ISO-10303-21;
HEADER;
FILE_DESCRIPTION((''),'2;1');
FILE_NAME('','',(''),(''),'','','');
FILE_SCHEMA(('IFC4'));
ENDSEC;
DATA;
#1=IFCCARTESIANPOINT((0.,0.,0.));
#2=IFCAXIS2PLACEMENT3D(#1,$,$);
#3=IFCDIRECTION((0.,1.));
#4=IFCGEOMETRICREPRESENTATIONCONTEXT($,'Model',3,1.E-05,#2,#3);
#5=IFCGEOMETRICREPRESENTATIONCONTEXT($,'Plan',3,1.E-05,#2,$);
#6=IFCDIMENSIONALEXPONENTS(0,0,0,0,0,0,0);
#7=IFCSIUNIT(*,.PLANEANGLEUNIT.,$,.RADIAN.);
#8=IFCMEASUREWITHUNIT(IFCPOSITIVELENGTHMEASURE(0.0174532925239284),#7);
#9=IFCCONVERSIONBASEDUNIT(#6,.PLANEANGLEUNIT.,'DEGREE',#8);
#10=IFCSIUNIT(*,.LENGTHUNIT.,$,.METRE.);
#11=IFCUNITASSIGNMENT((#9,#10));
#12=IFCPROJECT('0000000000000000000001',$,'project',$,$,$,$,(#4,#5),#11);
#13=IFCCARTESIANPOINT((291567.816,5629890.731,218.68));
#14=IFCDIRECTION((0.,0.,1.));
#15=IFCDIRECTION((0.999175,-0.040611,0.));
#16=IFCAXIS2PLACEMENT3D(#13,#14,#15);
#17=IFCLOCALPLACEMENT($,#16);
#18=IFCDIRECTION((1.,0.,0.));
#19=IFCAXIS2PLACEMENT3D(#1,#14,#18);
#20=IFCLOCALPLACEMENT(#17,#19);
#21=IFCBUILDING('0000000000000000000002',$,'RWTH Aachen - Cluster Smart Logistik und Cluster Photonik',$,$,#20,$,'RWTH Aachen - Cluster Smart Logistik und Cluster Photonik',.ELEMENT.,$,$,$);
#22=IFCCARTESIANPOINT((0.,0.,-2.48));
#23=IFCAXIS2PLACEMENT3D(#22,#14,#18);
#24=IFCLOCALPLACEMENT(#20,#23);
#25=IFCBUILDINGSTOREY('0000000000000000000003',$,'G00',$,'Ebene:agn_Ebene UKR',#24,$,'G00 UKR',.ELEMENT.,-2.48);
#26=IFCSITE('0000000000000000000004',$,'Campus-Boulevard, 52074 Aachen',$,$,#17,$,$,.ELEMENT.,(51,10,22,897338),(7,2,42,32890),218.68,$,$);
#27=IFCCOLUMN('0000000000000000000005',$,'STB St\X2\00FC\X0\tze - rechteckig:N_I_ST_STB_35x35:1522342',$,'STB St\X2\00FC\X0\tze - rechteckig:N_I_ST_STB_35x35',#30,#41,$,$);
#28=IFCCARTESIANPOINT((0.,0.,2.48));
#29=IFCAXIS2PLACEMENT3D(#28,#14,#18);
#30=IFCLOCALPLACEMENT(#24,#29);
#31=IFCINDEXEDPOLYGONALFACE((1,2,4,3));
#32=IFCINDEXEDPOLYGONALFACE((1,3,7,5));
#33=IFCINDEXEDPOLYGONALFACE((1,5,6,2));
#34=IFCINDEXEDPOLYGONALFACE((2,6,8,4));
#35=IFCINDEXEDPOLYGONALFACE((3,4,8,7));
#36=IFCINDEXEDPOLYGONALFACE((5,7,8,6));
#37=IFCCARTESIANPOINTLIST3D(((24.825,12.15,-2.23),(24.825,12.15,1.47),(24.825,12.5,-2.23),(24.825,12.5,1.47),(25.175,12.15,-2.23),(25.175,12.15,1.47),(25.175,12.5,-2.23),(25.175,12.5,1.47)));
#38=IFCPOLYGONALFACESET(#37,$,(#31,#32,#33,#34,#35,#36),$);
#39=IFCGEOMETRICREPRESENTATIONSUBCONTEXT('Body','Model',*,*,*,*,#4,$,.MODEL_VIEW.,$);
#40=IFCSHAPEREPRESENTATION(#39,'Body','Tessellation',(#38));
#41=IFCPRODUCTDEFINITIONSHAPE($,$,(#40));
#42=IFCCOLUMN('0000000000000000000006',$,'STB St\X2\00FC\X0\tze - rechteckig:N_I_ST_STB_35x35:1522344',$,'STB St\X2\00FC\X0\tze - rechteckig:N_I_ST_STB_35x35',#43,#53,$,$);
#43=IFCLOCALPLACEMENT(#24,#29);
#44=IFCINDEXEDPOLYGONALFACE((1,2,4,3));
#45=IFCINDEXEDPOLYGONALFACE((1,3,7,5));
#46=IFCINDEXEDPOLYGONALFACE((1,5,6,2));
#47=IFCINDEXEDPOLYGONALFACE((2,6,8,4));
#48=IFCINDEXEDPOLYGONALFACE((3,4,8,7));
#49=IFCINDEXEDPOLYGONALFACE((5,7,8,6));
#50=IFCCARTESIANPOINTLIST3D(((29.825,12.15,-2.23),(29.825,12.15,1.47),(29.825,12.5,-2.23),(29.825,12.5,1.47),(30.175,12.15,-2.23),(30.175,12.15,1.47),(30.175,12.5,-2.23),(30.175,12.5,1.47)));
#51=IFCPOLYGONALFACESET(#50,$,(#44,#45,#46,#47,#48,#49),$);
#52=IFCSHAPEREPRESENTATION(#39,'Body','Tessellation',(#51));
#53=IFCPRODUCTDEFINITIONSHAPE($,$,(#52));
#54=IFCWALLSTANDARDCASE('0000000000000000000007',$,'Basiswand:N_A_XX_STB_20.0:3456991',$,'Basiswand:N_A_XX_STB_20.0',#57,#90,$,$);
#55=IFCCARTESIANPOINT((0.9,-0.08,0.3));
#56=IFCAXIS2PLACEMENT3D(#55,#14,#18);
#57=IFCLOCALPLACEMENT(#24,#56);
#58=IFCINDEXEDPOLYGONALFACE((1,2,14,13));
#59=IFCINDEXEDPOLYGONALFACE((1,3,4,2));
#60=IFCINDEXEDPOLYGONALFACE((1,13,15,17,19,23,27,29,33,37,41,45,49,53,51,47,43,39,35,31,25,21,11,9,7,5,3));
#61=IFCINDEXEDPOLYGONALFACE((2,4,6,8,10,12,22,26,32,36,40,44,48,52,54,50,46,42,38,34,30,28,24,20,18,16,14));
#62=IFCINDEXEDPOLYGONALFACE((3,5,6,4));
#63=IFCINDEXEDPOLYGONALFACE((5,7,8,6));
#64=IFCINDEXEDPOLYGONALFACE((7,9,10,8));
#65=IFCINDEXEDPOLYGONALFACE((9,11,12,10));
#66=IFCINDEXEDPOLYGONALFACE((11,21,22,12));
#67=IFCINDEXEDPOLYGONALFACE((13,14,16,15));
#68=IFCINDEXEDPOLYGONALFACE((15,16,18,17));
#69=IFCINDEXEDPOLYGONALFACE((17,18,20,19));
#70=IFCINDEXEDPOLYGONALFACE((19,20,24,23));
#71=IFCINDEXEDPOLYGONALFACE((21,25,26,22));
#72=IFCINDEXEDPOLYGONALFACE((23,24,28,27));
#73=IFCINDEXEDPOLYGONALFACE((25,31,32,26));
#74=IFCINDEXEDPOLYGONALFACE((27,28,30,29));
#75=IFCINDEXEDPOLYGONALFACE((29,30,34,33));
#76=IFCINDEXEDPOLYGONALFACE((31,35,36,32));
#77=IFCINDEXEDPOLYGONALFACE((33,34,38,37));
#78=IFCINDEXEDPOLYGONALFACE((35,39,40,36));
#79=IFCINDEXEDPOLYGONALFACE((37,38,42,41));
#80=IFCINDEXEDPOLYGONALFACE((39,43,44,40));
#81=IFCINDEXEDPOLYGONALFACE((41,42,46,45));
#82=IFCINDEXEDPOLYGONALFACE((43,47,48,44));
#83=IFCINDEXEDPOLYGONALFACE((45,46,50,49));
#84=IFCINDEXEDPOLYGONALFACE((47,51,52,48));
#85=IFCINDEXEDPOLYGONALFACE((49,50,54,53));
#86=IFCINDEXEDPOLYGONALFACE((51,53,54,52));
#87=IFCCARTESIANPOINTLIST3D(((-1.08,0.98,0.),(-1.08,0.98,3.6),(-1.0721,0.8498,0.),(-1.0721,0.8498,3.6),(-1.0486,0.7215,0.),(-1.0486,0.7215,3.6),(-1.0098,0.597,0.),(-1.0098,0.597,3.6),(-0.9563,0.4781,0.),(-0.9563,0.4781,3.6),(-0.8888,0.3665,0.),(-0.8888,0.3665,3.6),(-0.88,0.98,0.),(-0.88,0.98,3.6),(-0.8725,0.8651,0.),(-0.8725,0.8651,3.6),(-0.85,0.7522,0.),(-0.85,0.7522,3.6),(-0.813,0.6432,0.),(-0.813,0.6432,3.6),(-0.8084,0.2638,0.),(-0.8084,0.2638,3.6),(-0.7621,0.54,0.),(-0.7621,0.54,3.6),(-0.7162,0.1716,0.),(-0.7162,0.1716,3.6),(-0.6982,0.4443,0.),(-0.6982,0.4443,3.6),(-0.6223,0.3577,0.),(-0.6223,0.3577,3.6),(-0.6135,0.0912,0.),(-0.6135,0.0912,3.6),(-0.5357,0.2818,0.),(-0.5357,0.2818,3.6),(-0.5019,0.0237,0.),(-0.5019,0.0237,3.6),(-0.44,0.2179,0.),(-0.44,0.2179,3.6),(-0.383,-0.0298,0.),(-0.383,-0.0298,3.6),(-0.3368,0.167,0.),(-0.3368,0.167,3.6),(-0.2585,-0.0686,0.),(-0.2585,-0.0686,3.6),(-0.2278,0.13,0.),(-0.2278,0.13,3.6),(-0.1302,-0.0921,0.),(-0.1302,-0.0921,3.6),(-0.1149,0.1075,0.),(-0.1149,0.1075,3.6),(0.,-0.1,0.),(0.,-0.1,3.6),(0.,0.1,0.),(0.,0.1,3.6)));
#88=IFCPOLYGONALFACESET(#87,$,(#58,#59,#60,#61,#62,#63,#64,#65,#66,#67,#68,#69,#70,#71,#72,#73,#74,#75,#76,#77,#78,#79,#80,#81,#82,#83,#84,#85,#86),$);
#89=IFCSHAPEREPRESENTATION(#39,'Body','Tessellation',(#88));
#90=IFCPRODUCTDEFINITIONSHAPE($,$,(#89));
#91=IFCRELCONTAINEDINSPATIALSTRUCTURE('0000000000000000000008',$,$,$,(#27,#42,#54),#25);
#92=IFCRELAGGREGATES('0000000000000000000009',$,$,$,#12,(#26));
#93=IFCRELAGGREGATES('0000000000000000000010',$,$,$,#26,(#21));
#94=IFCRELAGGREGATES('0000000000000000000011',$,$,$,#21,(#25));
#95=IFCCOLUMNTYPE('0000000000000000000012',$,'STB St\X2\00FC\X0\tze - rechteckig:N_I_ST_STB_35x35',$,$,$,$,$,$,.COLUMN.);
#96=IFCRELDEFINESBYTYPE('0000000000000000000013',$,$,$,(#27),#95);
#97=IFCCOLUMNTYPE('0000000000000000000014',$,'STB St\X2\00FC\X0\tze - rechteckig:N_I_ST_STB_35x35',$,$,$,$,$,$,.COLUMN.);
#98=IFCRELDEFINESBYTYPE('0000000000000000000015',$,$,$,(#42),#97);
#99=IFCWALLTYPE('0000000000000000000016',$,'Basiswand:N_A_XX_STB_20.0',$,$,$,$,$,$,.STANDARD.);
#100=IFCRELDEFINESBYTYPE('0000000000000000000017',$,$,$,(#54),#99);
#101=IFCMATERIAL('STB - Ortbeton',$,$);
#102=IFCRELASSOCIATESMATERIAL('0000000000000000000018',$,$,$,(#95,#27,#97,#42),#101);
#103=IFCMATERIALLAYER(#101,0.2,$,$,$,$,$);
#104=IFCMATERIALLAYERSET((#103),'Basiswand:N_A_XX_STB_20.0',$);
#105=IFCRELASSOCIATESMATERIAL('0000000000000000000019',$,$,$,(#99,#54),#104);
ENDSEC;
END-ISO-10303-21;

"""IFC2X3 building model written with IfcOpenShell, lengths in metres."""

from ifc_helpers import new_model, entity, si_unit, converted_unit, direction, frame, frame_2d, origin, origin_with_axes, origin_2d_with_axis, place, context, subcontext, project, spatial, polyline, circle_curve, parameter, trimmed, segment, composite_curve, rectangle, outline, extrude, source, transform, mapped, material, layer, layer_set, layer_usage, type_object, element, save


model = new_model("IFC2X3")

# Units and contexts
model_context = context("Model", 3, precision=1e-05, world=origin(), true_north=direction((0.0, 1.0)))
plan_context = context("Plan", 3, precision=1e-05, world=origin())
body_context = subcontext(model_context, "Body", "Model", "MODEL_VIEW")
ifc_project = project(units=[converted_unit("PLANEANGLEUNIT", "DEGREE", entity("IfcPositiveLengthMeasure", 0.0174532925239284), si_unit("PLANEANGLEUNIT", "RADIAN"), dimensions=[0, 0, 0, 0, 0, 0, 0]), si_unit("LENGTHUNIT", "METRE")], contexts=[model_context, plan_context])

# Site, building, storey
site_placement = place(None, frame((291567.816, 5629890.731, 218.68), z_axis=(0.0, 0.0, 1.0), x_axis=(0.999175, -0.040611, 0.0)))
site = spatial("IfcSite", under=ifc_project, at=site_placement, Name="Campus-Boulevard, 52074 Aachen", CompositionType="ELEMENT", RefLatitude=(51, 10, 22, 897338), RefLongitude=(7, 2, 42, 32890), RefElevation=218.68)
building_placement = place(site_placement, origin_with_axes())
building = spatial("IfcBuilding", under=site, at=building_placement, Name="RWTH Aachen - Cluster Smart Logistik und Cluster Photonik", LongName="RWTH Aachen - Cluster Smart Logistik und Cluster Photonik", CompositionType="ELEMENT")
storey_placement = place(building_placement, frame((0.0, 0.0, -2.48), z_axis=(0.0, 0.0, 1.0), x_axis=(1.0, 0.0, 0.0)))
storey = spatial("IfcBuildingStorey", under=building, at=storey_placement, Name="G00", ObjectType="Ebene:agn_Ebene UKR", LongName="G00 UKR", CompositionType="ELEMENT", Elevation=-2.48)

# Shared definitions
ifc_material = material(Name="STB - Ortbeton")

# Columns
column_type_1 = type_object("IfcColumnType", Name="STB Stütze - rechteckig:N_I_ST_STB_35x35", PredefinedType="COLUMN", material=ifc_material)
shared_shape_1 = source(origin(), body_context, "Body", "SweptSolid", [
    extrude(rectangle(XDim=0.35, YDim=0.35, at=origin_2d_with_axis()), frame((25.0, 12.325, -2.23), z_axis=(0.0, 0.0, 1.0), x_axis=(0.0, -1.0, 0.0)), (0.0, 0.0, 1.0), 3.7),
])
column_1_placement = place(storey_placement, frame((0.0, 0.0, 2.48), z_axis=(0.0, 0.0, 1.0), x_axis=(1.0, 0.0, 0.0)))
element("IfcColumn", 1, at=column_1_placement, inside=storey, type_object=column_type_1, material=ifc_material, Name="STB Stütze - rechteckig:N_I_ST_STB_35x35:1522342", ObjectType="STB Stütze - rechteckig:N_I_ST_STB_35x35", context=body_context, shape_type="MappedRepresentation", body=[
    mapped(shared_shape_1, transform((0.0, 0.0, 0.0), scale=1.0)),
])
column_type_2 = type_object("IfcColumnType", Name="STB Stütze - rechteckig:N_I_ST_STB_35x35", PredefinedType="COLUMN", material=ifc_material)
shared_shape_2 = source(origin(), body_context, "Body", "SweptSolid", [
    extrude(rectangle(XDim=0.35, YDim=0.35, at=origin_2d_with_axis()), frame((30.0, 12.325, -2.23), z_axis=(0.0, 0.0, 1.0), x_axis=(0.0, -1.0, 0.0)), (0.0, 0.0, 1.0), 3.7),
])
column_2_placement = place(storey_placement, frame((0.0, 0.0, 2.48), z_axis=(0.0, 0.0, 1.0), x_axis=(1.0, 0.0, 0.0)))
element("IfcColumn", 2, at=column_2_placement, inside=storey, type_object=column_type_2, material=ifc_material, Name="STB Stütze - rechteckig:N_I_ST_STB_35x35:1522344", ObjectType="STB Stütze - rechteckig:N_I_ST_STB_35x35", context=body_context, shape_type="MappedRepresentation", body=[
    mapped(shared_shape_2, transform((0.0, 0.0, 0.0), scale=1.0)),
])

# Wall
ifc_layer = layer(ifc_material, 0.2)
ifc_layer_set = layer_set([ifc_layer], Name="Basiswand:N_A_XX_STB_20.0")
wall_type = type_object("IfcWallType", Name="Basiswand:N_A_XX_STB_20.0", PredefinedType="STANDARD", material=ifc_layer_set)
ifc_layer_usage_1 = layer_usage(ifc_layer_set, "AXIS2", "POSITIVE", -0.1)
wall_1_placement = place(storey_placement, frame((0.9, -0.08, 0.3), z_axis=(0.0, 0.0, 1.0), x_axis=(1.0, 0.0, 0.0)))
element("IfcWallStandardCase", 3, at=wall_1_placement, inside=storey, type_object=wall_type, material=ifc_layer_usage_1, Name="Basiswand:N_A_XX_STB_20.0:3456991", ObjectType="Basiswand:N_A_XX_STB_20.0", context=body_context, shape_type="SweptSolid", body=[
    extrude(outline(composite_curve([segment(trimmed(circle_curve(frame_2d((0.0, 0.98), x_axis=(1.0, 0.0)), 1.08), [parameter(180.0)], [parameter(270.0)], True, "PARAMETER"), True, "CONTINUOUS"), segment(polyline([(0.0, -0.1), (0.0, 0.1)]), True, "CONTINUOUS"), segment(trimmed(circle_curve(frame_2d((0.0, 0.98), x_axis=(1.0, 0.0)), 0.88), [parameter(180.0)], [parameter(270.0)], True, "PARAMETER"), False, "CONTINUOUS"), segment(polyline([(-0.88, 0.98), (-1.08, 0.98)]), True, "CONTINUOUS")], self_intersect=False)), origin(), (0.0, 0.0, 1.0), 3.6),
])

save(model, "model.ifc")
